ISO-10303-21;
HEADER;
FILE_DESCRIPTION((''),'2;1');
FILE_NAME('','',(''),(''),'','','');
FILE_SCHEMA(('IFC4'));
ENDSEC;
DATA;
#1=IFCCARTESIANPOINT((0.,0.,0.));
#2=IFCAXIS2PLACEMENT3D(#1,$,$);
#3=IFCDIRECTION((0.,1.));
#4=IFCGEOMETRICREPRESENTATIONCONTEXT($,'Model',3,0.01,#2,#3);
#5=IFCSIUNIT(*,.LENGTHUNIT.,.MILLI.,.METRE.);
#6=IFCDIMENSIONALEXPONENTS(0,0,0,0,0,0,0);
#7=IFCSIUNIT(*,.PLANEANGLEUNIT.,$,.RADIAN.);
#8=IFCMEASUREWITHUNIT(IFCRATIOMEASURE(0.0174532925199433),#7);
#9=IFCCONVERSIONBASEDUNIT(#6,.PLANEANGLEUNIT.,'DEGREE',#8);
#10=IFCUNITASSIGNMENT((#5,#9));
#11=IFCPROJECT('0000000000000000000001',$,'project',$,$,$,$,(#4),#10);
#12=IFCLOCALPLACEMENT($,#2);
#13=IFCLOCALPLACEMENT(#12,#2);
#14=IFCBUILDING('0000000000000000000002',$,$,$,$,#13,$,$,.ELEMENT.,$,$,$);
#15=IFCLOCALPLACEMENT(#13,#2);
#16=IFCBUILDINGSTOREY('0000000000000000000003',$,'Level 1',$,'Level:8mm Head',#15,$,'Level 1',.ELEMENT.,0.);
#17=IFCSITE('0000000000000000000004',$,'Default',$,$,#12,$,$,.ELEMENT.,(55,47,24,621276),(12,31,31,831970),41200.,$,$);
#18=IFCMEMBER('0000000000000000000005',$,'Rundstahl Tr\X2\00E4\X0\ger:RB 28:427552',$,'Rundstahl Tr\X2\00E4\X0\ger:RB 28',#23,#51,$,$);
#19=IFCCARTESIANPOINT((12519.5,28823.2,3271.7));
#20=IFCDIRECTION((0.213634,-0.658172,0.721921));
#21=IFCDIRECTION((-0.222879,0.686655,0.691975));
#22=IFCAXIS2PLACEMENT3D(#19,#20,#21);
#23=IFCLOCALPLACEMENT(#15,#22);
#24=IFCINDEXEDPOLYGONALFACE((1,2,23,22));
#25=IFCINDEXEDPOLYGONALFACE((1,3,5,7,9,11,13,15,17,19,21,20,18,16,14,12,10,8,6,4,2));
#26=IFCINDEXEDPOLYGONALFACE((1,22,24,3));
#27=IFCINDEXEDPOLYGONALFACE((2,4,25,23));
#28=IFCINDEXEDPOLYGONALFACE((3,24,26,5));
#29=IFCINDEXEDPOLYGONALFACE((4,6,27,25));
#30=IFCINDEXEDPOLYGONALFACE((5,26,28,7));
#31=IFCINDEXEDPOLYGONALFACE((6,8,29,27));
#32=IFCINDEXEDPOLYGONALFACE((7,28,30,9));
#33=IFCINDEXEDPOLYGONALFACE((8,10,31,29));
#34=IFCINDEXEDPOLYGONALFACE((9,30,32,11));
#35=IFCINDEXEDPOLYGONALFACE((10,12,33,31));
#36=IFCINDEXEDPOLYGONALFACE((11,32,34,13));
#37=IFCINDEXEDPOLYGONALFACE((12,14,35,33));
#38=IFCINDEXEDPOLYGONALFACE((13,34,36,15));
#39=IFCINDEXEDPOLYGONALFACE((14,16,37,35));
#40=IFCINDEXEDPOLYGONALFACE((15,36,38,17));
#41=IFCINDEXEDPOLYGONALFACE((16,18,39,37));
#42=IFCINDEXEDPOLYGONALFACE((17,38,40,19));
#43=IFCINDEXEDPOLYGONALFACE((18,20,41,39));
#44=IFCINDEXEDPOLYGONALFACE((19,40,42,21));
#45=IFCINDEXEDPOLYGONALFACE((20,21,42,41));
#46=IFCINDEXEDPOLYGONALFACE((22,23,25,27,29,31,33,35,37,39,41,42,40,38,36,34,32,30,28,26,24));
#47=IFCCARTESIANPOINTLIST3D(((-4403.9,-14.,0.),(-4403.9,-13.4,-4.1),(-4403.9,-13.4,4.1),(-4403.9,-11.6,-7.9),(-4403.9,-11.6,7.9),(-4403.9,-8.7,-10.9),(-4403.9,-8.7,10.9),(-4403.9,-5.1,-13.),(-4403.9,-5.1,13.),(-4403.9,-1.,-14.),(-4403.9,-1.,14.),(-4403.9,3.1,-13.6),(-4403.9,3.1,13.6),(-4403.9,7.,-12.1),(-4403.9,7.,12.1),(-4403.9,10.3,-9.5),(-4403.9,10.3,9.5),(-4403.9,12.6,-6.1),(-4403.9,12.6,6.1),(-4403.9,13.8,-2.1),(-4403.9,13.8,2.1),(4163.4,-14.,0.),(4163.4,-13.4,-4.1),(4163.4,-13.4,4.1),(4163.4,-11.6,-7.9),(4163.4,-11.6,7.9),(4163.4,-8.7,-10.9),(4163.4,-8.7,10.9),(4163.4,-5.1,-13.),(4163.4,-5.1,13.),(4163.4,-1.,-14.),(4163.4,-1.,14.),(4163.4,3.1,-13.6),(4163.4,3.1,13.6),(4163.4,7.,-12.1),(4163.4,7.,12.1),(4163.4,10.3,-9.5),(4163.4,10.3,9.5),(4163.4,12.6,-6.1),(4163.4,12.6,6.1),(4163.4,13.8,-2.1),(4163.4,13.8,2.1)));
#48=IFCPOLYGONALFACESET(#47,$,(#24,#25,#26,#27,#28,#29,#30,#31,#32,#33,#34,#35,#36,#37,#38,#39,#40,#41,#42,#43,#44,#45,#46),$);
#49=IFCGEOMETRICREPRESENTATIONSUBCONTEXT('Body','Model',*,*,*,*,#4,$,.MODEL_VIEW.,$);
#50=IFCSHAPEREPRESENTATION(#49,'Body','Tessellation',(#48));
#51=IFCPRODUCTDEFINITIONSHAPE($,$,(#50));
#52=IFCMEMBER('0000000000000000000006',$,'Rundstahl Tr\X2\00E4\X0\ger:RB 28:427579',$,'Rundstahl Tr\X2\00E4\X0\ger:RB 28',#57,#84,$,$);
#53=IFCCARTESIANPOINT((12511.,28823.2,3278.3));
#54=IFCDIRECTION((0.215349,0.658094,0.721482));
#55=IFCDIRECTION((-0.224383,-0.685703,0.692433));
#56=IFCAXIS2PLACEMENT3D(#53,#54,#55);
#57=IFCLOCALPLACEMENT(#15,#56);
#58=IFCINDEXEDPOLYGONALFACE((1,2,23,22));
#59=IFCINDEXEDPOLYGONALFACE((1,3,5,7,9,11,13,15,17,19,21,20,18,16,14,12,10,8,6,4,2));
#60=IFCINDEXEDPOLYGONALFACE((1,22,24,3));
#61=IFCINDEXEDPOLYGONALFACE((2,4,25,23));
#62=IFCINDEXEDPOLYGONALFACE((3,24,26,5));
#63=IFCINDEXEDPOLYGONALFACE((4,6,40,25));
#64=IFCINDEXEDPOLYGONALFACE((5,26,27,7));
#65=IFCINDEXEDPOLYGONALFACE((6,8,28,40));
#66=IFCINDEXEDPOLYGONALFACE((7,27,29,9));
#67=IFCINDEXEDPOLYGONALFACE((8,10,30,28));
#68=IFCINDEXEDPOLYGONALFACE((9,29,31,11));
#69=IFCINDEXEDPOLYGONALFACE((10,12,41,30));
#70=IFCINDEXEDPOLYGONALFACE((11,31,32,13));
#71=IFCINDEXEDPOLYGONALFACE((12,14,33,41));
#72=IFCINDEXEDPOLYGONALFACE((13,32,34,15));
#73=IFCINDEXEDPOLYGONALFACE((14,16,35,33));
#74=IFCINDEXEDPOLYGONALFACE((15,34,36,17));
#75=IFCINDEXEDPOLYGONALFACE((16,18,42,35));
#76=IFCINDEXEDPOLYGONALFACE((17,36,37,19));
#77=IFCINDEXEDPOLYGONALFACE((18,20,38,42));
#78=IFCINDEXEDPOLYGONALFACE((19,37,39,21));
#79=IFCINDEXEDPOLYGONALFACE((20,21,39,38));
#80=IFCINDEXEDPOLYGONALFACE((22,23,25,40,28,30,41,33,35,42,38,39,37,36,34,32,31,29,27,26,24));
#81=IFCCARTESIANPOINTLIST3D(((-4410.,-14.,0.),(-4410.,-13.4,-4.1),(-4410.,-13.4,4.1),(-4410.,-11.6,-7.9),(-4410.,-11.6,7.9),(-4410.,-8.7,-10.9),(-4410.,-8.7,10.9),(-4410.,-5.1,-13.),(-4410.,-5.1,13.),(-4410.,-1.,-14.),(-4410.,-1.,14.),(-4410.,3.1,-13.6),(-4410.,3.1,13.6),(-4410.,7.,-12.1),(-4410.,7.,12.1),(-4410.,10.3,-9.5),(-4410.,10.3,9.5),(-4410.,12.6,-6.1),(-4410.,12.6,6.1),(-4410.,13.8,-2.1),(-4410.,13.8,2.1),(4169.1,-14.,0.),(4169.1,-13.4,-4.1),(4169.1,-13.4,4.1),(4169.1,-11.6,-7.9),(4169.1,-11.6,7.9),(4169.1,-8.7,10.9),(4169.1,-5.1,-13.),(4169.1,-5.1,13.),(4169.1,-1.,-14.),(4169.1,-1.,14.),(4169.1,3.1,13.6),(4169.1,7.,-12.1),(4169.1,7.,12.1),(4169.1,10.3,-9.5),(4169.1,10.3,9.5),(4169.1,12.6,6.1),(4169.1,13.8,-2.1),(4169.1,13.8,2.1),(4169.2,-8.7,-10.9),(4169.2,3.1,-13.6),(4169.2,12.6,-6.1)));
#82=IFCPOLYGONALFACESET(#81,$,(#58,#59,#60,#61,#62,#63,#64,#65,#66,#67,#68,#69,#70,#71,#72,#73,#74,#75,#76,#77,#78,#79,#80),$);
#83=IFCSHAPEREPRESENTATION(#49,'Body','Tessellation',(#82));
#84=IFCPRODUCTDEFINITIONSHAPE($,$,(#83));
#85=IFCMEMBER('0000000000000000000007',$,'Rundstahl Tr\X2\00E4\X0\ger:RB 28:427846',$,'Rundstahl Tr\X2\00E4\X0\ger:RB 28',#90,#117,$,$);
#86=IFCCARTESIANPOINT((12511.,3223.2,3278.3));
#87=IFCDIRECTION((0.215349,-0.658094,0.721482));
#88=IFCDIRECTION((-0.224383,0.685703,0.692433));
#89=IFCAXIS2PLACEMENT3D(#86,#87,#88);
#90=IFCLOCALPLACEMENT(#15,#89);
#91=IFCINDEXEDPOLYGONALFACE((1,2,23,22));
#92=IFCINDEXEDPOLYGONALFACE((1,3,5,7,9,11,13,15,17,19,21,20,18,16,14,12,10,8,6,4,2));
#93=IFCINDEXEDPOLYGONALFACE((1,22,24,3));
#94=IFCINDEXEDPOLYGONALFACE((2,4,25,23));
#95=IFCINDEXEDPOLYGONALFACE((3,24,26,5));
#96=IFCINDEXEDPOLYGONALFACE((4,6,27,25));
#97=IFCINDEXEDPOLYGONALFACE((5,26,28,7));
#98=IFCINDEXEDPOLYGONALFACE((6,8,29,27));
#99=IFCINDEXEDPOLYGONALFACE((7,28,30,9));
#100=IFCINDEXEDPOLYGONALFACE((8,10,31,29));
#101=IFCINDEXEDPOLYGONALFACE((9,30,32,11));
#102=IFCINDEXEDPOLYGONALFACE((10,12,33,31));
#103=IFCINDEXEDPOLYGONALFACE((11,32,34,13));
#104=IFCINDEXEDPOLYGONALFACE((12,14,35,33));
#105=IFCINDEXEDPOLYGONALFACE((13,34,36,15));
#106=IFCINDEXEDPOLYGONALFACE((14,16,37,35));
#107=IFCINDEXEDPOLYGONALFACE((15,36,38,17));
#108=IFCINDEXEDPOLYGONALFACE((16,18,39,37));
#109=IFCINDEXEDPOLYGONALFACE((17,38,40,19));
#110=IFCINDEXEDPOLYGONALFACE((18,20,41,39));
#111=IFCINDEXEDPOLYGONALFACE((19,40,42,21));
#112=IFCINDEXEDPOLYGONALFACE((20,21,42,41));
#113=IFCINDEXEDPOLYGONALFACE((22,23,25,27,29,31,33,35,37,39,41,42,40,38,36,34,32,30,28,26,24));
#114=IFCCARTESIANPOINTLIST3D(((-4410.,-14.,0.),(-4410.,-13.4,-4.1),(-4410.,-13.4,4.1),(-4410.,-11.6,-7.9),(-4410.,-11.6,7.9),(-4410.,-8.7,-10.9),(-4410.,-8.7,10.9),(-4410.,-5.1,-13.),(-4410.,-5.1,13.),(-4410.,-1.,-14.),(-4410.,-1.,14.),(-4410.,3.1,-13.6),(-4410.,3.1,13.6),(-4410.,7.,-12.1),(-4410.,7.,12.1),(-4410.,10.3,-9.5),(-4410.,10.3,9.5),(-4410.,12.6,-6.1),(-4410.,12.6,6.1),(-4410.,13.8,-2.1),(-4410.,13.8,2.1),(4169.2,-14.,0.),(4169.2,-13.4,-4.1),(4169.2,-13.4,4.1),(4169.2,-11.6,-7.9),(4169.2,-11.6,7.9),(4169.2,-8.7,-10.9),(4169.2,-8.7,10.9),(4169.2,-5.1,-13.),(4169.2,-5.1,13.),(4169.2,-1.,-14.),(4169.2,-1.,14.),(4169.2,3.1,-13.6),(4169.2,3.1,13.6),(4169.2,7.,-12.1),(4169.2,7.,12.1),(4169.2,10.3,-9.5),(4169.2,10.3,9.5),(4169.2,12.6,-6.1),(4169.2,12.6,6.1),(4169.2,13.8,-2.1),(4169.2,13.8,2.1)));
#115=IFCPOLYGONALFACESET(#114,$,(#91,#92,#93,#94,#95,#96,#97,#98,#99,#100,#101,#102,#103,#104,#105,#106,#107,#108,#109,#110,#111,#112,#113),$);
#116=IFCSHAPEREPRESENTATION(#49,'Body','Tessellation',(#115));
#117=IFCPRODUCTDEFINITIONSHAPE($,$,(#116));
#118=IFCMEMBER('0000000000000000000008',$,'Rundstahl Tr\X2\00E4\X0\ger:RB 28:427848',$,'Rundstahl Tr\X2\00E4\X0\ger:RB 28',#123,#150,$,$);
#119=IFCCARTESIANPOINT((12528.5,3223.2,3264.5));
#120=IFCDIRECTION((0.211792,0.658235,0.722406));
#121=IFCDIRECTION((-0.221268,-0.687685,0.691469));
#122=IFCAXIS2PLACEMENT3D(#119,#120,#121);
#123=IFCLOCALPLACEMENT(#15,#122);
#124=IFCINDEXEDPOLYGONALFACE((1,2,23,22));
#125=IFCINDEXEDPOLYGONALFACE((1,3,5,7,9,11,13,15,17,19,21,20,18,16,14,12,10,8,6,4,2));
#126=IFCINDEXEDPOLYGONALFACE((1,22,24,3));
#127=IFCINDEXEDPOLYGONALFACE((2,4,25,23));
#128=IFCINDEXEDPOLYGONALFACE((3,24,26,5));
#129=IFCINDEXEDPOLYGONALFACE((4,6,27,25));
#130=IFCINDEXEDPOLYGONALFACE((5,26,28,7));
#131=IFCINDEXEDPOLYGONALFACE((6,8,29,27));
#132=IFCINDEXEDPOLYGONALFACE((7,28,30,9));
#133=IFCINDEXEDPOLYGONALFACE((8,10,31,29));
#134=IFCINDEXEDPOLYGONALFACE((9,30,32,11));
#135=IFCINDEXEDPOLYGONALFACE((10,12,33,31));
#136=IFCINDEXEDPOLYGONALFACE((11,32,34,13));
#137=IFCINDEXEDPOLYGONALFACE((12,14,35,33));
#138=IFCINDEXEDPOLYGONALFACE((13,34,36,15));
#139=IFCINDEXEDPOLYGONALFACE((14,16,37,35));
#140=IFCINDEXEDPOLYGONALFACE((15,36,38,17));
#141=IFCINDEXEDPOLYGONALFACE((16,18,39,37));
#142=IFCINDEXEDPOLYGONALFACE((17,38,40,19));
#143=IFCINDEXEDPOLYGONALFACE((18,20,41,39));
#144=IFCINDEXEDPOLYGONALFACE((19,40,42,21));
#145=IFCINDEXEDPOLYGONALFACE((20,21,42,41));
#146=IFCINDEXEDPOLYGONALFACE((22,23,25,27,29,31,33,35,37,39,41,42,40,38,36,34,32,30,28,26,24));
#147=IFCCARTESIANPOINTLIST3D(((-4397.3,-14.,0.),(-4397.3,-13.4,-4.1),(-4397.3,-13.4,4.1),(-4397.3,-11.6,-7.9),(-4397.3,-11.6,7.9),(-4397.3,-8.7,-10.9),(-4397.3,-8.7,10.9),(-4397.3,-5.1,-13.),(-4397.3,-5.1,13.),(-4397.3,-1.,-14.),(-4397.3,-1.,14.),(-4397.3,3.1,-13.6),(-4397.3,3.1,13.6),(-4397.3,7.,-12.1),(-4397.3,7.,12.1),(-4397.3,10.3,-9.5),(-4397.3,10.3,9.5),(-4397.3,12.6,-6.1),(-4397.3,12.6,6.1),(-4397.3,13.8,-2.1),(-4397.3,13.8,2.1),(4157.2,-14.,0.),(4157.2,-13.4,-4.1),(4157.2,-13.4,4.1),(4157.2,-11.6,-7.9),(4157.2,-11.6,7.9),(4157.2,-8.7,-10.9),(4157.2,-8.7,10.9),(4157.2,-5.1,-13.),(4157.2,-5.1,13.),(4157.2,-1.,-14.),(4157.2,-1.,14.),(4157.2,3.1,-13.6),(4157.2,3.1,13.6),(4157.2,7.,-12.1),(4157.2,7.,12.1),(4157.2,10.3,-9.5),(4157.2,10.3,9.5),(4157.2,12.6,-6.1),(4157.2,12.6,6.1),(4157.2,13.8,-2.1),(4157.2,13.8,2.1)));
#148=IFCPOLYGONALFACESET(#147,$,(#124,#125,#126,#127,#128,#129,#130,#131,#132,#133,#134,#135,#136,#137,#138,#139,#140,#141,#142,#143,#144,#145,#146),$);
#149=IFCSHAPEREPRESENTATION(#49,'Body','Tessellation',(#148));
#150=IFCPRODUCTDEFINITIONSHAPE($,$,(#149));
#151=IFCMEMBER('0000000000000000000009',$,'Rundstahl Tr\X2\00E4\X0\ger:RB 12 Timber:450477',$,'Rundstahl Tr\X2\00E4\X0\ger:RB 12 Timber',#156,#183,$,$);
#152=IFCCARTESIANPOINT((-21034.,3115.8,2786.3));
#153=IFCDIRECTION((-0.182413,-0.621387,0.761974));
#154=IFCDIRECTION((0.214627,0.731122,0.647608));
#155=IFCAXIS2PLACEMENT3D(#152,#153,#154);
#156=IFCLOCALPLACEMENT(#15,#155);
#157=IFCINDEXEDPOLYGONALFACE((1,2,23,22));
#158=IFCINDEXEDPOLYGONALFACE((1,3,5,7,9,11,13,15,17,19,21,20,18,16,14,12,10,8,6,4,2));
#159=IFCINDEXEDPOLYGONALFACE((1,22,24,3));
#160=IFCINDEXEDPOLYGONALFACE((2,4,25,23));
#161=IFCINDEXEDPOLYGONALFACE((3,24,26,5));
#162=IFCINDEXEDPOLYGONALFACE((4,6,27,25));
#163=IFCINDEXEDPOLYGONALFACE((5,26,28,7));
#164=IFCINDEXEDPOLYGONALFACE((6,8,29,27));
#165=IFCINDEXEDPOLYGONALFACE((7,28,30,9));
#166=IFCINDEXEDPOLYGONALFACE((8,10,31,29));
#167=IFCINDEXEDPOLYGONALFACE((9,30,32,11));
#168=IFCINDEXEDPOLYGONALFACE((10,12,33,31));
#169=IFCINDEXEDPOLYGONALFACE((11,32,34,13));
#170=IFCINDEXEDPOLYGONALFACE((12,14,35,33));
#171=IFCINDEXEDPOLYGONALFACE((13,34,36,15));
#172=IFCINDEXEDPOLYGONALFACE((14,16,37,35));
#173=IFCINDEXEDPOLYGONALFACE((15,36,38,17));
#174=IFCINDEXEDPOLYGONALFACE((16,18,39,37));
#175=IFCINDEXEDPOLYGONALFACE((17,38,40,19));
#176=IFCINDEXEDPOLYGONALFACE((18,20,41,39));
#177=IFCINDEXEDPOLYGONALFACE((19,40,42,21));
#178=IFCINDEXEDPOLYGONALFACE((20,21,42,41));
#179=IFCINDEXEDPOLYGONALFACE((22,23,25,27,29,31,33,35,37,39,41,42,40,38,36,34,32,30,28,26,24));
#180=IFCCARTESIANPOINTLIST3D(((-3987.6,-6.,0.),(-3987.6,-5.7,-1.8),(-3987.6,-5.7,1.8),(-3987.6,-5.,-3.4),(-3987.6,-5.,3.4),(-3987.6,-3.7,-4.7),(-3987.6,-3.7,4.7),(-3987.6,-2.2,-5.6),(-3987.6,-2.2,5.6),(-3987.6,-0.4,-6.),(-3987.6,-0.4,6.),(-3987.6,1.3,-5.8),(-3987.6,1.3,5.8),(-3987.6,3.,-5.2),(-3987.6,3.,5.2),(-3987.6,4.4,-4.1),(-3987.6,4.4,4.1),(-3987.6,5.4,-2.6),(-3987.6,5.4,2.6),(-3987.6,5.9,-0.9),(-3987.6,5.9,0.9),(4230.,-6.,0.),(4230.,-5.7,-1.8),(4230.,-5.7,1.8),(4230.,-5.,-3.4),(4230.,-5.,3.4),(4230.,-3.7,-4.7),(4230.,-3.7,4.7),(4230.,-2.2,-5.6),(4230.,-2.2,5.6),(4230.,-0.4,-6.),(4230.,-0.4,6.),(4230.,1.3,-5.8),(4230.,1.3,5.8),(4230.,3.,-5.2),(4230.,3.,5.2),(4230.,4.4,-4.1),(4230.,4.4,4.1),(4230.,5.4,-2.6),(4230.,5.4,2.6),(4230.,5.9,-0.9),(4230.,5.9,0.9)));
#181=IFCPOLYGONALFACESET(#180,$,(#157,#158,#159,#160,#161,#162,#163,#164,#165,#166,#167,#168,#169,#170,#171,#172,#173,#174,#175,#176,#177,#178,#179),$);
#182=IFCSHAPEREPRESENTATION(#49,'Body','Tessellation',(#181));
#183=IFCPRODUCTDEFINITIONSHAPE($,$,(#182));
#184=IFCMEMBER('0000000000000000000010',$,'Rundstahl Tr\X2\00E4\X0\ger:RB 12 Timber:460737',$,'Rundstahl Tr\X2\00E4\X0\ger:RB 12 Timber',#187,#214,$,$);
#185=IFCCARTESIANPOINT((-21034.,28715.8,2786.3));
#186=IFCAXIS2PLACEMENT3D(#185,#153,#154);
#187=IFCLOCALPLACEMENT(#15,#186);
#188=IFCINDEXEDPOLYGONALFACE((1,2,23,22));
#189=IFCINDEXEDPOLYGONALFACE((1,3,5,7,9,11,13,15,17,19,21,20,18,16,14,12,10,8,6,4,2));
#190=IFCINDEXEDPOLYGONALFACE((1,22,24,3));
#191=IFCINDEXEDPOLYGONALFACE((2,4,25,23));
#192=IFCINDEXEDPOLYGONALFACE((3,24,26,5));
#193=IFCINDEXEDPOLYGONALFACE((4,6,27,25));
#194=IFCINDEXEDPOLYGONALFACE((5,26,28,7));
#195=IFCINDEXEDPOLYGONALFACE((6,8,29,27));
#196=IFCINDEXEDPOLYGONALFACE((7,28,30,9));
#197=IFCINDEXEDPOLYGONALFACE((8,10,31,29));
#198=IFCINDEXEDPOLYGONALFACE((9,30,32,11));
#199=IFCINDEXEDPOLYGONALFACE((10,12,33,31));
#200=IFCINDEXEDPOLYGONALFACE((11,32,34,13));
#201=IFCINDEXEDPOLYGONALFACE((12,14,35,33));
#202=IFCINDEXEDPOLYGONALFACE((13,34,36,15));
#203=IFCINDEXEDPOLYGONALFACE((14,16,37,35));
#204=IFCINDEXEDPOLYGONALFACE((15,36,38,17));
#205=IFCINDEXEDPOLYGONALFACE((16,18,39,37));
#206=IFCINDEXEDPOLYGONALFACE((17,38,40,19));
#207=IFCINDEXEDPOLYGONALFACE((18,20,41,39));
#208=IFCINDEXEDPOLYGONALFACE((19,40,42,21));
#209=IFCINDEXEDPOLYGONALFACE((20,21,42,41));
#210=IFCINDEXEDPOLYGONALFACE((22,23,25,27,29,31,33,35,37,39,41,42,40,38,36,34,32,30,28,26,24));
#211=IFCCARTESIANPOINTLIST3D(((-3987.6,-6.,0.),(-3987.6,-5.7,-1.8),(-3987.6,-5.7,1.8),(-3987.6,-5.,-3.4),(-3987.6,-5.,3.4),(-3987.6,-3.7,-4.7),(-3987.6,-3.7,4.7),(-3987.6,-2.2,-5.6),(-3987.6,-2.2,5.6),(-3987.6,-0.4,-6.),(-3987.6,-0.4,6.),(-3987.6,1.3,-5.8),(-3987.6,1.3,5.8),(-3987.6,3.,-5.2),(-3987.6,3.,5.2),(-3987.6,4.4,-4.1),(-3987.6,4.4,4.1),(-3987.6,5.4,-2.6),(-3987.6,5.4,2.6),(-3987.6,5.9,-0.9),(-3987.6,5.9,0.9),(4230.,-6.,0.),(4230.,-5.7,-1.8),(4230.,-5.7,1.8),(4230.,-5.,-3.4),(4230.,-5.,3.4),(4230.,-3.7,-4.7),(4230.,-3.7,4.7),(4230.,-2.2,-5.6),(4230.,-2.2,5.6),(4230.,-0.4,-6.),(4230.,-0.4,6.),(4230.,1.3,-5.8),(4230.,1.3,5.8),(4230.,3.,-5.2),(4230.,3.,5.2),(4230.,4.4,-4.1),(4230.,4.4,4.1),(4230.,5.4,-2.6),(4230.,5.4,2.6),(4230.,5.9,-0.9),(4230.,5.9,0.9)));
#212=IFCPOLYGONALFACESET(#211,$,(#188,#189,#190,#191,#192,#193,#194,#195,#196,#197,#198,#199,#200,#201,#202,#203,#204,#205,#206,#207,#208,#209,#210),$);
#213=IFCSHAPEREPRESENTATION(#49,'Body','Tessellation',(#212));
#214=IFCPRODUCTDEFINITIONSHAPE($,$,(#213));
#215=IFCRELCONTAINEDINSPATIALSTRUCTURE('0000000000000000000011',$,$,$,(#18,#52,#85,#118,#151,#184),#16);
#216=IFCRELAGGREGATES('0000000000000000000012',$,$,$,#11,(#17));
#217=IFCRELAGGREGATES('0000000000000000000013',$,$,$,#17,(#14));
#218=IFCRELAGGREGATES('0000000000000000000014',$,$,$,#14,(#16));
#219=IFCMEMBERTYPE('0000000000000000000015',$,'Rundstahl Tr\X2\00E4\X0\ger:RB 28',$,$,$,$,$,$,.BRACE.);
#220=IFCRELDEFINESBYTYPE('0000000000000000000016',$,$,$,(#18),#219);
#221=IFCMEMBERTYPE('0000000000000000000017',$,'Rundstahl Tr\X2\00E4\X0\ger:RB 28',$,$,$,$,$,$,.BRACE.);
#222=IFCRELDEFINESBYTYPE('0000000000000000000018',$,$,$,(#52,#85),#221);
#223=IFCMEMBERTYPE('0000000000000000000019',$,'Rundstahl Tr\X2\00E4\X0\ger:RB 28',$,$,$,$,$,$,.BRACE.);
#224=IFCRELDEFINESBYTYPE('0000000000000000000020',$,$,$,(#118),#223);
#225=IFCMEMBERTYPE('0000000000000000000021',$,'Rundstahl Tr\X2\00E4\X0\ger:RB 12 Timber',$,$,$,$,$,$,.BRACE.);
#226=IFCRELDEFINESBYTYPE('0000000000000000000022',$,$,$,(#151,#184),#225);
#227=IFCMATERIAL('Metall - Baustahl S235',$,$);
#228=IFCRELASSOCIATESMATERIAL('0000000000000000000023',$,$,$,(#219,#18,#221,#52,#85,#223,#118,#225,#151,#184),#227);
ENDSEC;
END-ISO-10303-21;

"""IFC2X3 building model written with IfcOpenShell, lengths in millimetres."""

from ifc_helpers import new_model, entity, si_unit, converted_unit, direction, frame, frame_2d, origin, place, context, subcontext, project, spatial, circle, extrude, source, transform, mapped, material, type_object, type_shapes, element, save


model = new_model("IFC2X3")

# Units and contexts
model_context = context("Model", 3, precision=0.01, world=origin(), true_north=direction((0.0, 1.0)))
body_context = subcontext(model_context, "Body", "Model", "MODEL_VIEW")
ifc_project = project(units=[si_unit("LENGTHUNIT", "METRE", prefix="MILLI"), converted_unit("PLANEANGLEUNIT", "DEGREE", entity("IfcRatioMeasure", 0.0174532925199433), si_unit("PLANEANGLEUNIT", "RADIAN"), dimensions=[0, 0, 0, 0, 0, 0, 0])], contexts=[model_context])

# Site, building, storey
site_placement = place(None, origin())
site = spatial("IfcSite", under=ifc_project, at=site_placement, Name="Default", CompositionType="ELEMENT", RefLatitude=(55, 47, 24, 621276), RefLongitude=(12, 31, 31, 831970), RefElevation=41200.0)
building_placement = place(site_placement, origin())
building = spatial("IfcBuilding", under=site, at=building_placement, CompositionType="ELEMENT")
storey_placement = place(building_placement, origin())
storey = spatial("IfcBuildingStorey", under=building, at=storey_placement, Name="Level 1", ObjectType="Level:8mm Head", LongName="Level 1", CompositionType="ELEMENT", Elevation=0.0)

# Members
ifc_material_1 = material(Name="Metall - Baustahl S235")
member_type_1 = type_object("IfcMemberType", Name="Rundstahl Träger:RB 28", PredefinedType="BRACE", material=ifc_material_1)
shared_shape_1 = source(origin(), body_context, "Body", "SweptSolid", [
    extrude(circle(Radius=14.0, at=frame_2d((0.0, 0.0), x_axis=(1.0, 0.0))), frame((-4403.9, 0.0, 0.0), z_axis=(1.0, 0.0, 0.0), x_axis=(0.0, -1.0, 0.0)), (0.0, 0.0, 1.0), 8567.3),
])
type_shapes(member_type_1, [shared_shape_1])
member_1_placement = place(storey_placement, frame((12519.5, 28823.2, 3271.7), z_axis=(0.213634, -0.658172, 0.721921), x_axis=(-0.222879, 0.686655, 0.691975)))
element("IfcMember", 1, at=member_1_placement, inside=storey, type_object=member_type_1, material=ifc_material_1, Name="Rundstahl Träger:RB 28:427552", ObjectType="Rundstahl Träger:RB 28", context=body_context, shape_type="MappedRepresentation", body=[
    mapped(shared_shape_1, transform((0.0, 0.0, 0.0), scale=1.0)),
])
member_type_2 = type_object("IfcMemberType", Name="Rundstahl Träger:RB 28", PredefinedType="BRACE", material=ifc_material_1)
shared_shape_2 = source(origin(), body_context, "Body", "SweptSolid", [
    extrude(circle(Radius=14.0, at=frame_2d((0.0, 0.0), x_axis=(1.0, 0.0))), frame((-4409.9, 0.0, 0.0), z_axis=(1.0, 0.0, 0.0), x_axis=(0.0, -1.0, 0.0)), (0.0, 0.0, 1.0), 8579.1),
])
type_shapes(member_type_2, [shared_shape_2])
for number, where, z_axis, x_axis, name in (
    (2, (12511.0, 28823.2, 3278.3), (0.215349, 0.658094, 0.721482), (-0.224383, -0.685703, 0.692433), "Rundstahl Träger:RB 28:427579"),
    (3, (12511.0, 3223.2, 3278.3), (0.215349, -0.658094, 0.721482), (-0.224383, 0.685703, 0.692433), "Rundstahl Träger:RB 28:427846"),
):
    element("IfcMember", number, at=place(storey_placement, frame(where, z_axis=z_axis, x_axis=x_axis)), inside=storey, type_object=member_type_2, material=ifc_material_1, Name=name, ObjectType="Rundstahl Träger:RB 28", context=body_context, shape_type="MappedRepresentation", body=[
        mapped(shared_shape_2, transform((0.0, 0.0, 0.0), scale=1.0)),
    ])
member_type_3 = type_object("IfcMemberType", Name="Rundstahl Träger:RB 28", PredefinedType="BRACE", material=ifc_material_1)
shared_shape_3 = source(origin(), body_context, "Body", "SweptSolid", [
    extrude(circle(Radius=14.0, at=frame_2d((0.0, 0.0), x_axis=(1.0, 0.0))), frame((-4397.3, 0.0, 0.0), z_axis=(1.0, 0.0, 0.0), x_axis=(0.0, -1.0, 0.0)), (0.0, 0.0, 1.0), 8554.5),
])
type_shapes(member_type_3, [shared_shape_3])
member_2_placement = place(storey_placement, frame((12528.5, 3223.2, 3264.5), z_axis=(0.211792, 0.658235, 0.722406), x_axis=(-0.221268, -0.687685, 0.691469)))
element("IfcMember", 4, at=member_2_placement, inside=storey, type_object=member_type_3, material=ifc_material_1, Name="Rundstahl Träger:RB 28:427848", ObjectType="Rundstahl Träger:RB 28", context=body_context, shape_type="MappedRepresentation", body=[
    mapped(shared_shape_3, transform((0.0, 0.0, 0.0), scale=1.0)),
])
member_type_4 = type_object("IfcMemberType", Name="Rundstahl Träger:RB 12 Timber", PredefinedType="BRACE", material=ifc_material_1)
shared_shape_4 = source(origin(), body_context, "Body", "SweptSolid", [
    extrude(circle(Radius=6.0, at=frame_2d((0.0, 0.0), x_axis=(1.0, 0.0))), frame((-3987.6, 0.0, 0.0), z_axis=(1.0, 0.0, 0.0), x_axis=(0.0, -1.0, 0.0)), (0.0, 0.0, 1.0), 8217.6),
])
type_shapes(member_type_4, [shared_shape_4])
for number, where, z_axis, x_axis, name in (
    (5, (-21034.0, 3115.8, 2786.3), (-0.182413, -0.621387, 0.761974), (0.214627, 0.731122, 0.647608), "Rundstahl Träger:RB 12 Timber:450477"),
    (6, (-21034.0, 28715.8, 2786.3), (-0.182413, -0.621387, 0.761974), (0.214627, 0.731122, 0.647608), "Rundstahl Träger:RB 12 Timber:460737"),
):
    element("IfcMember", number, at=place(storey_placement, frame(where, z_axis=z_axis, x_axis=x_axis)), inside=storey, type_object=member_type_4, material=ifc_material_1, Name=name, ObjectType="Rundstahl Träger:RB 12 Timber", context=body_context, shape_type="MappedRepresentation", body=[
        mapped(shared_shape_4, transform((0.0, 0.0, 0.0), scale=1.0)),
    ])

save(model, "model.ifc")
